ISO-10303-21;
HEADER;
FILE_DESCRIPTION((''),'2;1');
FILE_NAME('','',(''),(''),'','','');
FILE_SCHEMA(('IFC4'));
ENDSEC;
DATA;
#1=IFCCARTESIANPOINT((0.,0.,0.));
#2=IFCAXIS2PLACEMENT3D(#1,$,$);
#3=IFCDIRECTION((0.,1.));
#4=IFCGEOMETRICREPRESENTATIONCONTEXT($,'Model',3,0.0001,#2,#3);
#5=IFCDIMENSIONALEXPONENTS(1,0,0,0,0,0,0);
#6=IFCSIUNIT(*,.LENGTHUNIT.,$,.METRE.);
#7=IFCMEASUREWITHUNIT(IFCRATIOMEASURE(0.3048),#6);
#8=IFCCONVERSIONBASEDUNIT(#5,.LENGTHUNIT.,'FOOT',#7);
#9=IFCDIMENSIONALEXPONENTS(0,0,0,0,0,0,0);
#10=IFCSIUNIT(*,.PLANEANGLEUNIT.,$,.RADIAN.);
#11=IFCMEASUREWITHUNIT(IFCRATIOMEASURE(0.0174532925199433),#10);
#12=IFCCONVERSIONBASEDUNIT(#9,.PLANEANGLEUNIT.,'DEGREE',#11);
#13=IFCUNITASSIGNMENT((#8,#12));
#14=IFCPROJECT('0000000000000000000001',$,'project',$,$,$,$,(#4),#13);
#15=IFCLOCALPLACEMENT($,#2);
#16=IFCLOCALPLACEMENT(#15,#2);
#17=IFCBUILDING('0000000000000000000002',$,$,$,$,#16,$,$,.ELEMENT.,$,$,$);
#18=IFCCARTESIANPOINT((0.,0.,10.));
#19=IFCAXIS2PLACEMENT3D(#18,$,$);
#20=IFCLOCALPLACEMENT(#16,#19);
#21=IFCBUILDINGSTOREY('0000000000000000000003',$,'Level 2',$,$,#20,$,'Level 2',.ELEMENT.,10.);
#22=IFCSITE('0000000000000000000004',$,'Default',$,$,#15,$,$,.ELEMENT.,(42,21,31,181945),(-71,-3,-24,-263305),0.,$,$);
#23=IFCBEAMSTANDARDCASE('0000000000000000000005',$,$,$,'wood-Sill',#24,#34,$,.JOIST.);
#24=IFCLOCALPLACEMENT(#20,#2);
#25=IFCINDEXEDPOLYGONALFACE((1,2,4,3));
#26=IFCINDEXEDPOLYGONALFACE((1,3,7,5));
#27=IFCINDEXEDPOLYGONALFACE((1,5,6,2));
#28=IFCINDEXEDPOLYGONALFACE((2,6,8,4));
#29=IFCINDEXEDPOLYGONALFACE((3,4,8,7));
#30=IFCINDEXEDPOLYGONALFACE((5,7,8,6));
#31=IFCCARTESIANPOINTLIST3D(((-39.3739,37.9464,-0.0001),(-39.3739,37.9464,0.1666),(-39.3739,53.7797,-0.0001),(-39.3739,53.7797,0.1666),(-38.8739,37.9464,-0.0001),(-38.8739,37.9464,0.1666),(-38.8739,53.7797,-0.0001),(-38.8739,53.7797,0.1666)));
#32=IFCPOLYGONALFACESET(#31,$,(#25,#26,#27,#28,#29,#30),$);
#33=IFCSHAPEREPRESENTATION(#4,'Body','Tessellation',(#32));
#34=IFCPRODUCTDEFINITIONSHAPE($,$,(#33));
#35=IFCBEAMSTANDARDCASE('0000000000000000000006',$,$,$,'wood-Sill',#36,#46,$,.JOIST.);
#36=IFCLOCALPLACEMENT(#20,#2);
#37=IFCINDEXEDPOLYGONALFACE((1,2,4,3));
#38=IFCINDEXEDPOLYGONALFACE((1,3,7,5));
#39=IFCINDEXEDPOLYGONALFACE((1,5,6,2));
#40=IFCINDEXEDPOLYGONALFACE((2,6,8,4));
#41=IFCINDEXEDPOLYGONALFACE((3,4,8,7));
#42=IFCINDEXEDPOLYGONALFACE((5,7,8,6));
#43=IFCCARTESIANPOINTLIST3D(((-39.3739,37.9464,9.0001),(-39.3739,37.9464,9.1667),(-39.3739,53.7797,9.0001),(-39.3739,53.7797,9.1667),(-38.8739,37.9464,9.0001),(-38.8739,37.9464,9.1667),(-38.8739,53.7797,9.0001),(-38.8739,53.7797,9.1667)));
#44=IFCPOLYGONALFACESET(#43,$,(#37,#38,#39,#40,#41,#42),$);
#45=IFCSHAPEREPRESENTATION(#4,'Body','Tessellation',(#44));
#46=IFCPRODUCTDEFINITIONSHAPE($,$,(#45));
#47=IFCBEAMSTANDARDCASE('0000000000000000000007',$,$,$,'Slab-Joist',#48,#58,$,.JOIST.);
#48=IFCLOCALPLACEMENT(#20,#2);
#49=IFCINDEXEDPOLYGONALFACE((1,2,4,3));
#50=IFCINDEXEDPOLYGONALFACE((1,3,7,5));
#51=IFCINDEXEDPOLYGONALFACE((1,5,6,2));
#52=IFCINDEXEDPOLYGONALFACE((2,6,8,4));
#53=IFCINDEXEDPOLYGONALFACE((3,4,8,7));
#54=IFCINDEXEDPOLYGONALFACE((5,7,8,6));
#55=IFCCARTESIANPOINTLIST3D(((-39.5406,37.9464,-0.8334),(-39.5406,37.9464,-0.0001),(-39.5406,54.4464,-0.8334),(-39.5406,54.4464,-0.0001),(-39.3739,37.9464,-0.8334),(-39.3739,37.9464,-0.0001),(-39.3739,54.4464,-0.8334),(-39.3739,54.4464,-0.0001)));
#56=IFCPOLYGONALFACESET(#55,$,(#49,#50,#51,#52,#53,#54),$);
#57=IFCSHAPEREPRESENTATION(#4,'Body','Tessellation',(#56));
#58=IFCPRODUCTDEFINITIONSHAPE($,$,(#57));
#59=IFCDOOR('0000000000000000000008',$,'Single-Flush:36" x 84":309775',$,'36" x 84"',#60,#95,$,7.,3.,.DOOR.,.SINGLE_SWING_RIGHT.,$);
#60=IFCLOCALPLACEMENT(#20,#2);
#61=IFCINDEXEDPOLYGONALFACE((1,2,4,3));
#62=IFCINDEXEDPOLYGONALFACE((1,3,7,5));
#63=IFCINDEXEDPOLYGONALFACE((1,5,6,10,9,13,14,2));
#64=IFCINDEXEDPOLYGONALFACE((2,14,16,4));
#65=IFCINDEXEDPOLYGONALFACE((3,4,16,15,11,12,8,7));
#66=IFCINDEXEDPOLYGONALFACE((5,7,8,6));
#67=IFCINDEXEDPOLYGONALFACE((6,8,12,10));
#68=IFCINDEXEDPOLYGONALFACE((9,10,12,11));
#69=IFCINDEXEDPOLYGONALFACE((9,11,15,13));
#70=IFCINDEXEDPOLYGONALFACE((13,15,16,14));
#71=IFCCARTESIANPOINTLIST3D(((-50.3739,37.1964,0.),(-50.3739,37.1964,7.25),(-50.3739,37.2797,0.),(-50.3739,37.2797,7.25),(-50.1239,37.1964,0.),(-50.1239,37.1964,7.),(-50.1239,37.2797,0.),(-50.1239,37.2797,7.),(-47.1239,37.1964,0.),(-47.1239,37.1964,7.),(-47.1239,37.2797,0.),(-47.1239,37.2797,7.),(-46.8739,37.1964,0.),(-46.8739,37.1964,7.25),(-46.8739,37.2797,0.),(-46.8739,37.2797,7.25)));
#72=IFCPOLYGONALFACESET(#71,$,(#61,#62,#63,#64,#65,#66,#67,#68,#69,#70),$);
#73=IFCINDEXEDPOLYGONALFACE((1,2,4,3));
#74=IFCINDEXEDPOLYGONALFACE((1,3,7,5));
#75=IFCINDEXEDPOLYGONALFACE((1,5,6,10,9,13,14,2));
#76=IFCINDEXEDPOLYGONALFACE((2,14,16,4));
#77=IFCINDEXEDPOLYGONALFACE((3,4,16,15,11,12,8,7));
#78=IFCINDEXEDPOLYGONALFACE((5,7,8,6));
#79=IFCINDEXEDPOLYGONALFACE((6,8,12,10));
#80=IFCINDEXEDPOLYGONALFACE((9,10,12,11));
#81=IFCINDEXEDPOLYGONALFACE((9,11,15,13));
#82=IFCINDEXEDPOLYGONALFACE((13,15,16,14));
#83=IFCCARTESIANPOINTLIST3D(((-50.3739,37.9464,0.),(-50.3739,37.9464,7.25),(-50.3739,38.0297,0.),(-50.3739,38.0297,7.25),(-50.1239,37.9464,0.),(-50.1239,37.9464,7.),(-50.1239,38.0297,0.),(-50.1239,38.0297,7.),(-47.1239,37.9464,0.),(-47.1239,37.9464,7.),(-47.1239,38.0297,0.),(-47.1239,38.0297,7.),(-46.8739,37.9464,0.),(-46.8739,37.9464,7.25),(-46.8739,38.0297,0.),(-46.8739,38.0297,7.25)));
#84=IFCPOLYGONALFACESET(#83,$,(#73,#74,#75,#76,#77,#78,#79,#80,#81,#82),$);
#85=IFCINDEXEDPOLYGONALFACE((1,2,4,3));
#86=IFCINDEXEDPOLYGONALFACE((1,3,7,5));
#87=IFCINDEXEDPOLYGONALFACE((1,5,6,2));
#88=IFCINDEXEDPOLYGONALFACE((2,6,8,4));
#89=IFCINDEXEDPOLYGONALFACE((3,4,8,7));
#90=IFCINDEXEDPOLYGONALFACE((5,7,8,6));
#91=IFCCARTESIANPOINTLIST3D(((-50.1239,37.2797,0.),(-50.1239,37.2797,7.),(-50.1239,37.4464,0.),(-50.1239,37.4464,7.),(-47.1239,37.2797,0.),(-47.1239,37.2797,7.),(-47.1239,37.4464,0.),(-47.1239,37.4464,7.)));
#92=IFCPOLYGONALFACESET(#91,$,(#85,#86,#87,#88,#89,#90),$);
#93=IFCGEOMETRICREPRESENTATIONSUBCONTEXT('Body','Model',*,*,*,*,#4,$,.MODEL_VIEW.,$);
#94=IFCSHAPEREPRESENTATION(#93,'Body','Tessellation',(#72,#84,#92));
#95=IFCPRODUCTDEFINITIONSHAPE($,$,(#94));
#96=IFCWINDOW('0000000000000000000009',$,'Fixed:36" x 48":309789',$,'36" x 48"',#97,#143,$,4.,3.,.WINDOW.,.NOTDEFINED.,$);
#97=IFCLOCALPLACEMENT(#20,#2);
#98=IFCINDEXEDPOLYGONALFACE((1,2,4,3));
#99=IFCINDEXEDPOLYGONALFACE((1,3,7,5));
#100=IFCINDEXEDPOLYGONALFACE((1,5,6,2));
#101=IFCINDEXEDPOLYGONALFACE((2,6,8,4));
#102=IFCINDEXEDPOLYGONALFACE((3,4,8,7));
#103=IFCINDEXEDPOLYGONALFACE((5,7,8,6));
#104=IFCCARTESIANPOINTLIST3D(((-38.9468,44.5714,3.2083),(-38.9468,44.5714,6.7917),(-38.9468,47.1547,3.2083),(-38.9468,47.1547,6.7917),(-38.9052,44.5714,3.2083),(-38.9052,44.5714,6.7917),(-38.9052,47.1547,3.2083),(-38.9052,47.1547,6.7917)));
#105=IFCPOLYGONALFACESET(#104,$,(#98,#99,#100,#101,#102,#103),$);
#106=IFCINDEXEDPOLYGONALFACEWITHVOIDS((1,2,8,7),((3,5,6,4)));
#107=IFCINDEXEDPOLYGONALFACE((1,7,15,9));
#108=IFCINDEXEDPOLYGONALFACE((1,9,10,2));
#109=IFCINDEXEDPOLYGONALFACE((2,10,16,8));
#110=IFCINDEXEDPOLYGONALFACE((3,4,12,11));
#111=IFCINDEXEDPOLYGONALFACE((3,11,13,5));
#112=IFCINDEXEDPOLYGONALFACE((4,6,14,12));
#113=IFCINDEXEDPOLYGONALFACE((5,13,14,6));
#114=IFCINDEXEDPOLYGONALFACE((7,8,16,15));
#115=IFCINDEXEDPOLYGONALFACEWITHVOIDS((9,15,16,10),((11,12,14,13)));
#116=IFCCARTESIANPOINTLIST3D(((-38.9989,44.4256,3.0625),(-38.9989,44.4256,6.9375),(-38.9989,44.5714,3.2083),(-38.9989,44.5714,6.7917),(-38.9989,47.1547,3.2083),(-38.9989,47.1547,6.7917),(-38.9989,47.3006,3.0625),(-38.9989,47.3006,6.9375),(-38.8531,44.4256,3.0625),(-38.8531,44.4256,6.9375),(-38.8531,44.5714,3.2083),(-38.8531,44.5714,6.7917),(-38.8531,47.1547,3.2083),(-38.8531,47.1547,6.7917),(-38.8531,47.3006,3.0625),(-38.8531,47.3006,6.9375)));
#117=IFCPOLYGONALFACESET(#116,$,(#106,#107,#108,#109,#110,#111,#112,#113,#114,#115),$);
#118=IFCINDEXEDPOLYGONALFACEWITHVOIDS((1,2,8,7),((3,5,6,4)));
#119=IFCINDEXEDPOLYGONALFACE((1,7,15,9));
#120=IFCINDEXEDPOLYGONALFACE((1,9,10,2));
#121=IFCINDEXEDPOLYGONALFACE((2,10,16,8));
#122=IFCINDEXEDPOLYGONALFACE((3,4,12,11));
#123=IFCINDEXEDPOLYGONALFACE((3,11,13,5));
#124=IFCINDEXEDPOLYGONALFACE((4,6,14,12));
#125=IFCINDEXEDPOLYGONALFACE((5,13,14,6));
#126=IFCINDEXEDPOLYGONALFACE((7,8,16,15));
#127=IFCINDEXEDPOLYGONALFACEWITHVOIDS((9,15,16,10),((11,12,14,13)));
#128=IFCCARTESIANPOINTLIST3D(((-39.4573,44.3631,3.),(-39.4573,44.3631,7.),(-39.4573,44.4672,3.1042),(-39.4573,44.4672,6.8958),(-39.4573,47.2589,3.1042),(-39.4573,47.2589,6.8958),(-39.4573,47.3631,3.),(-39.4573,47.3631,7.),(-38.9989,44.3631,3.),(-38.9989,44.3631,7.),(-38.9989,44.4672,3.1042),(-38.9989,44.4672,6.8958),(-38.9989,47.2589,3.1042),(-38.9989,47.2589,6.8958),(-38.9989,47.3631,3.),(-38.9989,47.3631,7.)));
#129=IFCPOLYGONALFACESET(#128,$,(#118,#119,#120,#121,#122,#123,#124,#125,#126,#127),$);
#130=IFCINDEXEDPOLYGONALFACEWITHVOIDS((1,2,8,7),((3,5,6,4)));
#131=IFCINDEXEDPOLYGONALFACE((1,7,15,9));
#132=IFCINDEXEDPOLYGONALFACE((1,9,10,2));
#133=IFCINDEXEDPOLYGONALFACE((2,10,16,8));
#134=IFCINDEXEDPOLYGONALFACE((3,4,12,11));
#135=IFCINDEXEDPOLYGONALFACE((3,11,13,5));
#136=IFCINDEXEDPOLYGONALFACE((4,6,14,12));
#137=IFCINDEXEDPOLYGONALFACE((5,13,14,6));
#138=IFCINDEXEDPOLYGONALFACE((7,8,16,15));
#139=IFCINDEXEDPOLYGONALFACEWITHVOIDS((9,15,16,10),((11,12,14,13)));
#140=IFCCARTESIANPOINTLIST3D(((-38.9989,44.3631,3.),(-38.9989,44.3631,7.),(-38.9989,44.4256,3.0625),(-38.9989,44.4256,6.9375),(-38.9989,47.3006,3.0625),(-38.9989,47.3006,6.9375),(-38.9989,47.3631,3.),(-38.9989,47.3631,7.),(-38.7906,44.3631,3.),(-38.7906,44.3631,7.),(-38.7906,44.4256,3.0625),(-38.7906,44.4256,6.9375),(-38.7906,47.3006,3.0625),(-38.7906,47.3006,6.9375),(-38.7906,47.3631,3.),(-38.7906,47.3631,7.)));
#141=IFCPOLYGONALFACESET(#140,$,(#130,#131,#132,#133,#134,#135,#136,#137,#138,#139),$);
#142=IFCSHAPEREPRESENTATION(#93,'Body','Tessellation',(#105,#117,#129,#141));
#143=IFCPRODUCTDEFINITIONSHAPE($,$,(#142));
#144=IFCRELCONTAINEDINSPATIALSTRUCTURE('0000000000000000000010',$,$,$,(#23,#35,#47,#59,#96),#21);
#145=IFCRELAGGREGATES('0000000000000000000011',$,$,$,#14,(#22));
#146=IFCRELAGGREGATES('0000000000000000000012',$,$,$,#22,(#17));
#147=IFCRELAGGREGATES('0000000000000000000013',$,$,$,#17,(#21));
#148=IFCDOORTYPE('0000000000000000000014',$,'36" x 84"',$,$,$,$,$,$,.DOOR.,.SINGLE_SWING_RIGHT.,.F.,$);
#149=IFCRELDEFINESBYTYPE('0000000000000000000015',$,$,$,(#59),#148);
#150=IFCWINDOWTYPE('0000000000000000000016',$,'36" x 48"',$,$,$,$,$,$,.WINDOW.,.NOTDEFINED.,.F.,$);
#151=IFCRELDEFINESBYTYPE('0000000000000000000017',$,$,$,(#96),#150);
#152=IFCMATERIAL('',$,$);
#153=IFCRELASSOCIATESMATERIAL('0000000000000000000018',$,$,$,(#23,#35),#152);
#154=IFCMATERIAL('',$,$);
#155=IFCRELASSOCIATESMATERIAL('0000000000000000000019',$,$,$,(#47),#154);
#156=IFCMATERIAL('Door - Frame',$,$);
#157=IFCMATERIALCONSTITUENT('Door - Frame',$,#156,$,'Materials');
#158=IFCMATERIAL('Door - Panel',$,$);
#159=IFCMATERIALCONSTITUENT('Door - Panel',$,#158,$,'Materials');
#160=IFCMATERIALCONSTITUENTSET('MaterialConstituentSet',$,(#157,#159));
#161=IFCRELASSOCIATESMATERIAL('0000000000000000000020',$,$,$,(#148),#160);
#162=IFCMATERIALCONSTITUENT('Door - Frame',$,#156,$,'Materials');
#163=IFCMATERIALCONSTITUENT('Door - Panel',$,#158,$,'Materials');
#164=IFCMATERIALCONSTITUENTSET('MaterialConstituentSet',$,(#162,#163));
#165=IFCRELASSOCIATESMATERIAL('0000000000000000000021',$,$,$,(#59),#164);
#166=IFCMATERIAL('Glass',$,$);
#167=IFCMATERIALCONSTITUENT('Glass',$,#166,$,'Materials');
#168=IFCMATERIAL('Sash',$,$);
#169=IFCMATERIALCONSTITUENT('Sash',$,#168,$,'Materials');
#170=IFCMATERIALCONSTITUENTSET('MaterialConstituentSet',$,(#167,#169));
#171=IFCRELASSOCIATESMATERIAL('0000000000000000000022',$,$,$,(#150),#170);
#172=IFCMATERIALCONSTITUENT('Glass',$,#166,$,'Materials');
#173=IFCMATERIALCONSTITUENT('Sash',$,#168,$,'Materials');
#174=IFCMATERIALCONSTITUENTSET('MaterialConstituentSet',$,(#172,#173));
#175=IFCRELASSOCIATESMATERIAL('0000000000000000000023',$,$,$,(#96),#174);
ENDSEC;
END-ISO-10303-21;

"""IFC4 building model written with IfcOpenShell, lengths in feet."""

from ifc_helpers import new_model, entity, si_unit, converted_unit, direction, frame, frame_2d, origin, origin_with_axes, place, context, subcontext, project, spatial, polyline, rectangle, outline, extrude, source, transform, mapped, material, constituent, constituent_set, type_object, type_shapes, element, save


model = new_model("IFC4")

# Units and contexts
model_context = context("Model", 3, precision=0.0001, world=origin(), true_north=direction((0.0, 1.0)))
body_context = subcontext(model_context, "Body", "Model", "MODEL_VIEW")
ifc_project = project(units=[converted_unit("LENGTHUNIT", "FOOT", entity("IfcRatioMeasure", 0.3048), si_unit("LENGTHUNIT", "METRE"), dimensions=[1, 0, 0, 0, 0, 0, 0]), converted_unit("PLANEANGLEUNIT", "DEGREE", entity("IfcRatioMeasure", 0.0174532925199433), si_unit("PLANEANGLEUNIT", "RADIAN"), dimensions=[0, 0, 0, 0, 0, 0, 0])], contexts=[model_context])

# Site, building, storey
site_placement = place(None, origin())
site = spatial("IfcSite", under=ifc_project, at=site_placement, Name="Default", CompositionType="ELEMENT", RefLatitude=(42, 21, 31, 181945), RefLongitude=(-71, -3, -24, -263305), RefElevation=0.0)
building_placement = place(site_placement, origin())
building = spatial("IfcBuilding", under=site, at=building_placement, CompositionType="ELEMENT")
storey_placement = place(building_placement, frame((0.0, 0.0, 10.0)))
storey = spatial("IfcBuildingStorey", under=building, at=storey_placement, Name="Level 2", LongName="Level 2", CompositionType="ELEMENT", Elevation=10.0)

# Beams
placement_1 = place(storey_placement, frame((-21.2906, 37.6131, 0.0), z_axis=(0.0, 0.0, 1.0), x_axis=(-1.0, 0.0, 0.0)))
ifc_material_1 = material(Name="")
placement_2 = place(storey_placement, frame((-39.1239, 37.9464, 0.0), z_axis=(0.0, 0.0, 1.0), x_axis=(0.0, 1.0, 0.0)))
for number, where, z_axis, x_axis in (
    (1, (0.0, 0.0, 0.0833), (1.0, 0.0, 0.0), (0.0, 0.0, 1.0)),
    (2, (0.0, 0.0, 9.0834), (1.0, 0.0, 0.0), (0.0, 0.0, 1.0)),
):
    element("IfcBeamStandardCase", number, at=place(placement_2, frame(where, z_axis=z_axis, x_axis=x_axis)), inside=storey, material=ifc_material_1, ObjectType="wood-Sill", PredefinedType="JOIST", context=model_context, shape_type="SweptSolid", body=[
        extrude(rectangle(XDim=0.1667, YDim=0.5), origin_with_axes(), (0.0, 0.0, 1.0), 15.8333),
    ])
ifc_material_2 = material(Name="")
placement_3 = place(storey_placement, frame((-39.4573, 37.9464, 0.0), z_axis=(0.0, 0.0, 1.0), x_axis=(1.0, 0.0, 0.0)))
beam_1_placement = place(placement_3, frame((0.0, 0.0, -0.4167), z_axis=(0.0, 1.0, 0.0), x_axis=(-1.0, 0.0, 0.0)))
element("IfcBeamStandardCase", 3, at=beam_1_placement, inside=storey, material=ifc_material_2, ObjectType="Slab-Joist", PredefinedType="JOIST", context=model_context, shape_type="SweptSolid", body=[
    extrude(rectangle(XDim=0.1667, YDim=0.8333), origin_with_axes(), (0.0, 0.0, 1.0), 16.5),
])

# Door
ifc_material_3 = material(Name="Door - Frame")
ifc_constituent_1 = constituent(ifc_material_3, Name="Door - Frame", Category="Materials")
ifc_material_4 = material(Name="Door - Panel")
ifc_constituent_2 = constituent(ifc_material_4, Name="Door - Panel", Category="Materials")
ifc_constituent_set_1 = constituent_set(constituents=[ifc_constituent_1, ifc_constituent_2], Name="MaterialConstituentSet")
ifc_constituent_3 = constituent(ifc_material_3, Name="Door - Frame", Category="Materials")
ifc_constituent_4 = constituent(ifc_material_4, Name="Door - Panel", Category="Materials")
ifc_constituent_set_2 = constituent_set(constituents=[ifc_constituent_3, ifc_constituent_4], Name="MaterialConstituentSet")
door_type = type_object("IfcDoorType", Name="36\" x 84\"", OperationType="SINGLE_SWING_RIGHT", ParameterTakesPrecedence=False, PredefinedType="DOOR", material=ifc_constituent_set_2)
shared_shape_1 = source(origin(), body_context, "Body", "SweptSolid", [
    extrude(outline(polyline([(-1.75, -3.6875), (1.75, -3.6875), (1.75, 3.5625), (1.5, 3.5625), (1.5, -3.4375), (-1.5, -3.4375), (-1.5, 3.5625), (-1.75, 3.5625), (-1.75, -3.6875)])), frame((1.5, 0.6667, 3.5625), z_axis=(0.0, 1.0, 0.0), x_axis=(1.0, 0.0, 0.0)), (0.0, 0.0, 1.0), 0.0833),
    extrude(outline(polyline([(-3.6875, -1.75), (3.5625, -1.75), (3.5625, -1.5), (-3.4375, -1.5), (-3.4375, 1.5), (3.5625, 1.5), (3.5625, 1.75), (-3.6875, 1.75), (-3.6875, -1.75)])), frame((1.5, -0.0833, 3.5625), z_axis=(0.0, 1.0, 0.0), x_axis=(0.0, 0.0, -1.0)), (0.0, 0.0, 1.0), 0.0833),
    extrude(rectangle(XDim=0.1667, YDim=3.0, at=frame_2d((0.0, 0.0), x_axis=(1.0, 0.0))), frame((1.5, 0.5833, 0.0), z_axis=(0.0, 0.0, 1.0), x_axis=(0.0, 1.0, 0.0)), (0.0, 0.0, 1.0), 7.0),
])
type_shapes(door_type, [shared_shape_1])
placement_4 = place(placement_1, frame((25.8333, -0.3333, 0.0)))
door_placement = place(placement_4, origin())
element("IfcDoor", 4, at=door_placement, inside=storey, type_object=door_type, material=ifc_constituent_set_1, Name="Single-Flush:36\" x 84\":309775", ObjectType="36\" x 84\"", OperationType="SINGLE_SWING_RIGHT", OverallHeight=7.0, OverallWidth=3.0, PredefinedType="DOOR", context=body_context, shape_type="MappedRepresentation", body=[
    mapped(shared_shape_1, transform((0.0, 0.0, 0.0), scale=1.0)),
])

# Window
ifc_material_5 = material(Name="Glass")
ifc_constituent_5 = constituent(ifc_material_5, Name="Glass", Category="Materials")
ifc_material_6 = material(Name="Sash")
ifc_constituent_6 = constituent(ifc_material_6, Name="Sash", Category="Materials")
ifc_constituent_set_3 = constituent_set(constituents=[ifc_constituent_5, ifc_constituent_6], Name="MaterialConstituentSet")
ifc_constituent_7 = constituent(ifc_material_5, Name="Glass", Category="Materials")
ifc_constituent_8 = constituent(ifc_material_6, Name="Sash", Category="Materials")
ifc_constituent_set_4 = constituent_set(constituents=[ifc_constituent_7, ifc_constituent_8], Name="MaterialConstituentSet")
window_type = type_object("IfcWindowType", Name="36\" x 48\"", ParameterTakesPrecedence=False, PartitioningType="NOTDEFINED", PredefinedType="WINDOW", material=ifc_constituent_set_4)
shared_shape_2 = source(origin(), body_context, "Body", "SweptSolid", [
    extrude(rectangle(XDim=0.0417, YDim=2.5833, at=frame_2d((0.0, 0.0), x_axis=(1.0, 0.0))), frame((1.5, 0.5312, 0.2083), z_axis=(0.0, 0.0, 1.0), x_axis=(0.0, 1.0, 0.0)), (0.0, 0.0, 1.0), 3.5833),
    extrude(outline(polyline([(-1.4375, -1.9375), (1.4375, -1.9375), (1.4375, 1.9375), (-1.4375, 1.9375), (-1.4375, -1.9375)]), holes=[polyline([(-1.2917, -1.7917), (-1.2917, 1.7917), (1.2917, 1.7917), (1.2917, -1.7917), (-1.2917, -1.7917)])]), frame((1.5, 0.4583, 2.0), z_axis=(0.0, 1.0, 0.0), x_axis=(1.0, 0.0, 0.0)), (0.0, 0.0, 1.0), 0.1458),
    extrude(outline(polyline([(-1.5, -2.0), (1.5, -2.0), (1.5, 2.0), (-1.5, 2.0), (-1.5, -2.0)]), holes=[polyline([(-1.3958, -1.8958), (-1.3958, 1.8958), (1.3958, 1.8958), (1.3958, -1.8958), (-1.3958, -1.8958)])]), frame((1.5, 0.0, 2.0), z_axis=(0.0, 1.0, 0.0), x_axis=(1.0, 0.0, 0.0)), (0.0, 0.0, 1.0), 0.4583),
    extrude(outline(polyline([(-2.0, -1.5), (2.0, -1.5), (2.0, 1.5), (-2.0, 1.5), (-2.0, -1.5)]), holes=[polyline([(-1.9375, -1.4375), (-1.9375, 1.4375), (1.9375, 1.4375), (1.9375, -1.4375), (-1.9375, -1.4375)])]), frame((1.5, 0.4583, 2.0), z_axis=(0.0, 1.0, 0.0), x_axis=(0.0, 0.0, -1.0)), (0.0, 0.0, 1.0), 0.2083),
])
type_shapes(window_type, [shared_shape_2])
placement_5 = place(placement_2, frame((9.4167, 0.3333, 3.0)))
window_placement = place(placement_5, frame((0.0, 0.0, 0.0), z_axis=(0.0, 0.0, 1.0), x_axis=(-1.0, 0.0, 0.0)))
element("IfcWindow", 5, at=window_placement, inside=storey, type_object=window_type, material=ifc_constituent_set_3, Name="Fixed:36\" x 48\":309789", ObjectType="36\" x 48\"", OverallHeight=4.0, OverallWidth=3.0, PartitioningType="NOTDEFINED", PredefinedType="WINDOW", context=body_context, shape_type="MappedRepresentation", body=[
    mapped(shared_shape_2, transform((0.0, 0.0, 0.0), scale=1.0)),
])

save(model, "model.ifc")
